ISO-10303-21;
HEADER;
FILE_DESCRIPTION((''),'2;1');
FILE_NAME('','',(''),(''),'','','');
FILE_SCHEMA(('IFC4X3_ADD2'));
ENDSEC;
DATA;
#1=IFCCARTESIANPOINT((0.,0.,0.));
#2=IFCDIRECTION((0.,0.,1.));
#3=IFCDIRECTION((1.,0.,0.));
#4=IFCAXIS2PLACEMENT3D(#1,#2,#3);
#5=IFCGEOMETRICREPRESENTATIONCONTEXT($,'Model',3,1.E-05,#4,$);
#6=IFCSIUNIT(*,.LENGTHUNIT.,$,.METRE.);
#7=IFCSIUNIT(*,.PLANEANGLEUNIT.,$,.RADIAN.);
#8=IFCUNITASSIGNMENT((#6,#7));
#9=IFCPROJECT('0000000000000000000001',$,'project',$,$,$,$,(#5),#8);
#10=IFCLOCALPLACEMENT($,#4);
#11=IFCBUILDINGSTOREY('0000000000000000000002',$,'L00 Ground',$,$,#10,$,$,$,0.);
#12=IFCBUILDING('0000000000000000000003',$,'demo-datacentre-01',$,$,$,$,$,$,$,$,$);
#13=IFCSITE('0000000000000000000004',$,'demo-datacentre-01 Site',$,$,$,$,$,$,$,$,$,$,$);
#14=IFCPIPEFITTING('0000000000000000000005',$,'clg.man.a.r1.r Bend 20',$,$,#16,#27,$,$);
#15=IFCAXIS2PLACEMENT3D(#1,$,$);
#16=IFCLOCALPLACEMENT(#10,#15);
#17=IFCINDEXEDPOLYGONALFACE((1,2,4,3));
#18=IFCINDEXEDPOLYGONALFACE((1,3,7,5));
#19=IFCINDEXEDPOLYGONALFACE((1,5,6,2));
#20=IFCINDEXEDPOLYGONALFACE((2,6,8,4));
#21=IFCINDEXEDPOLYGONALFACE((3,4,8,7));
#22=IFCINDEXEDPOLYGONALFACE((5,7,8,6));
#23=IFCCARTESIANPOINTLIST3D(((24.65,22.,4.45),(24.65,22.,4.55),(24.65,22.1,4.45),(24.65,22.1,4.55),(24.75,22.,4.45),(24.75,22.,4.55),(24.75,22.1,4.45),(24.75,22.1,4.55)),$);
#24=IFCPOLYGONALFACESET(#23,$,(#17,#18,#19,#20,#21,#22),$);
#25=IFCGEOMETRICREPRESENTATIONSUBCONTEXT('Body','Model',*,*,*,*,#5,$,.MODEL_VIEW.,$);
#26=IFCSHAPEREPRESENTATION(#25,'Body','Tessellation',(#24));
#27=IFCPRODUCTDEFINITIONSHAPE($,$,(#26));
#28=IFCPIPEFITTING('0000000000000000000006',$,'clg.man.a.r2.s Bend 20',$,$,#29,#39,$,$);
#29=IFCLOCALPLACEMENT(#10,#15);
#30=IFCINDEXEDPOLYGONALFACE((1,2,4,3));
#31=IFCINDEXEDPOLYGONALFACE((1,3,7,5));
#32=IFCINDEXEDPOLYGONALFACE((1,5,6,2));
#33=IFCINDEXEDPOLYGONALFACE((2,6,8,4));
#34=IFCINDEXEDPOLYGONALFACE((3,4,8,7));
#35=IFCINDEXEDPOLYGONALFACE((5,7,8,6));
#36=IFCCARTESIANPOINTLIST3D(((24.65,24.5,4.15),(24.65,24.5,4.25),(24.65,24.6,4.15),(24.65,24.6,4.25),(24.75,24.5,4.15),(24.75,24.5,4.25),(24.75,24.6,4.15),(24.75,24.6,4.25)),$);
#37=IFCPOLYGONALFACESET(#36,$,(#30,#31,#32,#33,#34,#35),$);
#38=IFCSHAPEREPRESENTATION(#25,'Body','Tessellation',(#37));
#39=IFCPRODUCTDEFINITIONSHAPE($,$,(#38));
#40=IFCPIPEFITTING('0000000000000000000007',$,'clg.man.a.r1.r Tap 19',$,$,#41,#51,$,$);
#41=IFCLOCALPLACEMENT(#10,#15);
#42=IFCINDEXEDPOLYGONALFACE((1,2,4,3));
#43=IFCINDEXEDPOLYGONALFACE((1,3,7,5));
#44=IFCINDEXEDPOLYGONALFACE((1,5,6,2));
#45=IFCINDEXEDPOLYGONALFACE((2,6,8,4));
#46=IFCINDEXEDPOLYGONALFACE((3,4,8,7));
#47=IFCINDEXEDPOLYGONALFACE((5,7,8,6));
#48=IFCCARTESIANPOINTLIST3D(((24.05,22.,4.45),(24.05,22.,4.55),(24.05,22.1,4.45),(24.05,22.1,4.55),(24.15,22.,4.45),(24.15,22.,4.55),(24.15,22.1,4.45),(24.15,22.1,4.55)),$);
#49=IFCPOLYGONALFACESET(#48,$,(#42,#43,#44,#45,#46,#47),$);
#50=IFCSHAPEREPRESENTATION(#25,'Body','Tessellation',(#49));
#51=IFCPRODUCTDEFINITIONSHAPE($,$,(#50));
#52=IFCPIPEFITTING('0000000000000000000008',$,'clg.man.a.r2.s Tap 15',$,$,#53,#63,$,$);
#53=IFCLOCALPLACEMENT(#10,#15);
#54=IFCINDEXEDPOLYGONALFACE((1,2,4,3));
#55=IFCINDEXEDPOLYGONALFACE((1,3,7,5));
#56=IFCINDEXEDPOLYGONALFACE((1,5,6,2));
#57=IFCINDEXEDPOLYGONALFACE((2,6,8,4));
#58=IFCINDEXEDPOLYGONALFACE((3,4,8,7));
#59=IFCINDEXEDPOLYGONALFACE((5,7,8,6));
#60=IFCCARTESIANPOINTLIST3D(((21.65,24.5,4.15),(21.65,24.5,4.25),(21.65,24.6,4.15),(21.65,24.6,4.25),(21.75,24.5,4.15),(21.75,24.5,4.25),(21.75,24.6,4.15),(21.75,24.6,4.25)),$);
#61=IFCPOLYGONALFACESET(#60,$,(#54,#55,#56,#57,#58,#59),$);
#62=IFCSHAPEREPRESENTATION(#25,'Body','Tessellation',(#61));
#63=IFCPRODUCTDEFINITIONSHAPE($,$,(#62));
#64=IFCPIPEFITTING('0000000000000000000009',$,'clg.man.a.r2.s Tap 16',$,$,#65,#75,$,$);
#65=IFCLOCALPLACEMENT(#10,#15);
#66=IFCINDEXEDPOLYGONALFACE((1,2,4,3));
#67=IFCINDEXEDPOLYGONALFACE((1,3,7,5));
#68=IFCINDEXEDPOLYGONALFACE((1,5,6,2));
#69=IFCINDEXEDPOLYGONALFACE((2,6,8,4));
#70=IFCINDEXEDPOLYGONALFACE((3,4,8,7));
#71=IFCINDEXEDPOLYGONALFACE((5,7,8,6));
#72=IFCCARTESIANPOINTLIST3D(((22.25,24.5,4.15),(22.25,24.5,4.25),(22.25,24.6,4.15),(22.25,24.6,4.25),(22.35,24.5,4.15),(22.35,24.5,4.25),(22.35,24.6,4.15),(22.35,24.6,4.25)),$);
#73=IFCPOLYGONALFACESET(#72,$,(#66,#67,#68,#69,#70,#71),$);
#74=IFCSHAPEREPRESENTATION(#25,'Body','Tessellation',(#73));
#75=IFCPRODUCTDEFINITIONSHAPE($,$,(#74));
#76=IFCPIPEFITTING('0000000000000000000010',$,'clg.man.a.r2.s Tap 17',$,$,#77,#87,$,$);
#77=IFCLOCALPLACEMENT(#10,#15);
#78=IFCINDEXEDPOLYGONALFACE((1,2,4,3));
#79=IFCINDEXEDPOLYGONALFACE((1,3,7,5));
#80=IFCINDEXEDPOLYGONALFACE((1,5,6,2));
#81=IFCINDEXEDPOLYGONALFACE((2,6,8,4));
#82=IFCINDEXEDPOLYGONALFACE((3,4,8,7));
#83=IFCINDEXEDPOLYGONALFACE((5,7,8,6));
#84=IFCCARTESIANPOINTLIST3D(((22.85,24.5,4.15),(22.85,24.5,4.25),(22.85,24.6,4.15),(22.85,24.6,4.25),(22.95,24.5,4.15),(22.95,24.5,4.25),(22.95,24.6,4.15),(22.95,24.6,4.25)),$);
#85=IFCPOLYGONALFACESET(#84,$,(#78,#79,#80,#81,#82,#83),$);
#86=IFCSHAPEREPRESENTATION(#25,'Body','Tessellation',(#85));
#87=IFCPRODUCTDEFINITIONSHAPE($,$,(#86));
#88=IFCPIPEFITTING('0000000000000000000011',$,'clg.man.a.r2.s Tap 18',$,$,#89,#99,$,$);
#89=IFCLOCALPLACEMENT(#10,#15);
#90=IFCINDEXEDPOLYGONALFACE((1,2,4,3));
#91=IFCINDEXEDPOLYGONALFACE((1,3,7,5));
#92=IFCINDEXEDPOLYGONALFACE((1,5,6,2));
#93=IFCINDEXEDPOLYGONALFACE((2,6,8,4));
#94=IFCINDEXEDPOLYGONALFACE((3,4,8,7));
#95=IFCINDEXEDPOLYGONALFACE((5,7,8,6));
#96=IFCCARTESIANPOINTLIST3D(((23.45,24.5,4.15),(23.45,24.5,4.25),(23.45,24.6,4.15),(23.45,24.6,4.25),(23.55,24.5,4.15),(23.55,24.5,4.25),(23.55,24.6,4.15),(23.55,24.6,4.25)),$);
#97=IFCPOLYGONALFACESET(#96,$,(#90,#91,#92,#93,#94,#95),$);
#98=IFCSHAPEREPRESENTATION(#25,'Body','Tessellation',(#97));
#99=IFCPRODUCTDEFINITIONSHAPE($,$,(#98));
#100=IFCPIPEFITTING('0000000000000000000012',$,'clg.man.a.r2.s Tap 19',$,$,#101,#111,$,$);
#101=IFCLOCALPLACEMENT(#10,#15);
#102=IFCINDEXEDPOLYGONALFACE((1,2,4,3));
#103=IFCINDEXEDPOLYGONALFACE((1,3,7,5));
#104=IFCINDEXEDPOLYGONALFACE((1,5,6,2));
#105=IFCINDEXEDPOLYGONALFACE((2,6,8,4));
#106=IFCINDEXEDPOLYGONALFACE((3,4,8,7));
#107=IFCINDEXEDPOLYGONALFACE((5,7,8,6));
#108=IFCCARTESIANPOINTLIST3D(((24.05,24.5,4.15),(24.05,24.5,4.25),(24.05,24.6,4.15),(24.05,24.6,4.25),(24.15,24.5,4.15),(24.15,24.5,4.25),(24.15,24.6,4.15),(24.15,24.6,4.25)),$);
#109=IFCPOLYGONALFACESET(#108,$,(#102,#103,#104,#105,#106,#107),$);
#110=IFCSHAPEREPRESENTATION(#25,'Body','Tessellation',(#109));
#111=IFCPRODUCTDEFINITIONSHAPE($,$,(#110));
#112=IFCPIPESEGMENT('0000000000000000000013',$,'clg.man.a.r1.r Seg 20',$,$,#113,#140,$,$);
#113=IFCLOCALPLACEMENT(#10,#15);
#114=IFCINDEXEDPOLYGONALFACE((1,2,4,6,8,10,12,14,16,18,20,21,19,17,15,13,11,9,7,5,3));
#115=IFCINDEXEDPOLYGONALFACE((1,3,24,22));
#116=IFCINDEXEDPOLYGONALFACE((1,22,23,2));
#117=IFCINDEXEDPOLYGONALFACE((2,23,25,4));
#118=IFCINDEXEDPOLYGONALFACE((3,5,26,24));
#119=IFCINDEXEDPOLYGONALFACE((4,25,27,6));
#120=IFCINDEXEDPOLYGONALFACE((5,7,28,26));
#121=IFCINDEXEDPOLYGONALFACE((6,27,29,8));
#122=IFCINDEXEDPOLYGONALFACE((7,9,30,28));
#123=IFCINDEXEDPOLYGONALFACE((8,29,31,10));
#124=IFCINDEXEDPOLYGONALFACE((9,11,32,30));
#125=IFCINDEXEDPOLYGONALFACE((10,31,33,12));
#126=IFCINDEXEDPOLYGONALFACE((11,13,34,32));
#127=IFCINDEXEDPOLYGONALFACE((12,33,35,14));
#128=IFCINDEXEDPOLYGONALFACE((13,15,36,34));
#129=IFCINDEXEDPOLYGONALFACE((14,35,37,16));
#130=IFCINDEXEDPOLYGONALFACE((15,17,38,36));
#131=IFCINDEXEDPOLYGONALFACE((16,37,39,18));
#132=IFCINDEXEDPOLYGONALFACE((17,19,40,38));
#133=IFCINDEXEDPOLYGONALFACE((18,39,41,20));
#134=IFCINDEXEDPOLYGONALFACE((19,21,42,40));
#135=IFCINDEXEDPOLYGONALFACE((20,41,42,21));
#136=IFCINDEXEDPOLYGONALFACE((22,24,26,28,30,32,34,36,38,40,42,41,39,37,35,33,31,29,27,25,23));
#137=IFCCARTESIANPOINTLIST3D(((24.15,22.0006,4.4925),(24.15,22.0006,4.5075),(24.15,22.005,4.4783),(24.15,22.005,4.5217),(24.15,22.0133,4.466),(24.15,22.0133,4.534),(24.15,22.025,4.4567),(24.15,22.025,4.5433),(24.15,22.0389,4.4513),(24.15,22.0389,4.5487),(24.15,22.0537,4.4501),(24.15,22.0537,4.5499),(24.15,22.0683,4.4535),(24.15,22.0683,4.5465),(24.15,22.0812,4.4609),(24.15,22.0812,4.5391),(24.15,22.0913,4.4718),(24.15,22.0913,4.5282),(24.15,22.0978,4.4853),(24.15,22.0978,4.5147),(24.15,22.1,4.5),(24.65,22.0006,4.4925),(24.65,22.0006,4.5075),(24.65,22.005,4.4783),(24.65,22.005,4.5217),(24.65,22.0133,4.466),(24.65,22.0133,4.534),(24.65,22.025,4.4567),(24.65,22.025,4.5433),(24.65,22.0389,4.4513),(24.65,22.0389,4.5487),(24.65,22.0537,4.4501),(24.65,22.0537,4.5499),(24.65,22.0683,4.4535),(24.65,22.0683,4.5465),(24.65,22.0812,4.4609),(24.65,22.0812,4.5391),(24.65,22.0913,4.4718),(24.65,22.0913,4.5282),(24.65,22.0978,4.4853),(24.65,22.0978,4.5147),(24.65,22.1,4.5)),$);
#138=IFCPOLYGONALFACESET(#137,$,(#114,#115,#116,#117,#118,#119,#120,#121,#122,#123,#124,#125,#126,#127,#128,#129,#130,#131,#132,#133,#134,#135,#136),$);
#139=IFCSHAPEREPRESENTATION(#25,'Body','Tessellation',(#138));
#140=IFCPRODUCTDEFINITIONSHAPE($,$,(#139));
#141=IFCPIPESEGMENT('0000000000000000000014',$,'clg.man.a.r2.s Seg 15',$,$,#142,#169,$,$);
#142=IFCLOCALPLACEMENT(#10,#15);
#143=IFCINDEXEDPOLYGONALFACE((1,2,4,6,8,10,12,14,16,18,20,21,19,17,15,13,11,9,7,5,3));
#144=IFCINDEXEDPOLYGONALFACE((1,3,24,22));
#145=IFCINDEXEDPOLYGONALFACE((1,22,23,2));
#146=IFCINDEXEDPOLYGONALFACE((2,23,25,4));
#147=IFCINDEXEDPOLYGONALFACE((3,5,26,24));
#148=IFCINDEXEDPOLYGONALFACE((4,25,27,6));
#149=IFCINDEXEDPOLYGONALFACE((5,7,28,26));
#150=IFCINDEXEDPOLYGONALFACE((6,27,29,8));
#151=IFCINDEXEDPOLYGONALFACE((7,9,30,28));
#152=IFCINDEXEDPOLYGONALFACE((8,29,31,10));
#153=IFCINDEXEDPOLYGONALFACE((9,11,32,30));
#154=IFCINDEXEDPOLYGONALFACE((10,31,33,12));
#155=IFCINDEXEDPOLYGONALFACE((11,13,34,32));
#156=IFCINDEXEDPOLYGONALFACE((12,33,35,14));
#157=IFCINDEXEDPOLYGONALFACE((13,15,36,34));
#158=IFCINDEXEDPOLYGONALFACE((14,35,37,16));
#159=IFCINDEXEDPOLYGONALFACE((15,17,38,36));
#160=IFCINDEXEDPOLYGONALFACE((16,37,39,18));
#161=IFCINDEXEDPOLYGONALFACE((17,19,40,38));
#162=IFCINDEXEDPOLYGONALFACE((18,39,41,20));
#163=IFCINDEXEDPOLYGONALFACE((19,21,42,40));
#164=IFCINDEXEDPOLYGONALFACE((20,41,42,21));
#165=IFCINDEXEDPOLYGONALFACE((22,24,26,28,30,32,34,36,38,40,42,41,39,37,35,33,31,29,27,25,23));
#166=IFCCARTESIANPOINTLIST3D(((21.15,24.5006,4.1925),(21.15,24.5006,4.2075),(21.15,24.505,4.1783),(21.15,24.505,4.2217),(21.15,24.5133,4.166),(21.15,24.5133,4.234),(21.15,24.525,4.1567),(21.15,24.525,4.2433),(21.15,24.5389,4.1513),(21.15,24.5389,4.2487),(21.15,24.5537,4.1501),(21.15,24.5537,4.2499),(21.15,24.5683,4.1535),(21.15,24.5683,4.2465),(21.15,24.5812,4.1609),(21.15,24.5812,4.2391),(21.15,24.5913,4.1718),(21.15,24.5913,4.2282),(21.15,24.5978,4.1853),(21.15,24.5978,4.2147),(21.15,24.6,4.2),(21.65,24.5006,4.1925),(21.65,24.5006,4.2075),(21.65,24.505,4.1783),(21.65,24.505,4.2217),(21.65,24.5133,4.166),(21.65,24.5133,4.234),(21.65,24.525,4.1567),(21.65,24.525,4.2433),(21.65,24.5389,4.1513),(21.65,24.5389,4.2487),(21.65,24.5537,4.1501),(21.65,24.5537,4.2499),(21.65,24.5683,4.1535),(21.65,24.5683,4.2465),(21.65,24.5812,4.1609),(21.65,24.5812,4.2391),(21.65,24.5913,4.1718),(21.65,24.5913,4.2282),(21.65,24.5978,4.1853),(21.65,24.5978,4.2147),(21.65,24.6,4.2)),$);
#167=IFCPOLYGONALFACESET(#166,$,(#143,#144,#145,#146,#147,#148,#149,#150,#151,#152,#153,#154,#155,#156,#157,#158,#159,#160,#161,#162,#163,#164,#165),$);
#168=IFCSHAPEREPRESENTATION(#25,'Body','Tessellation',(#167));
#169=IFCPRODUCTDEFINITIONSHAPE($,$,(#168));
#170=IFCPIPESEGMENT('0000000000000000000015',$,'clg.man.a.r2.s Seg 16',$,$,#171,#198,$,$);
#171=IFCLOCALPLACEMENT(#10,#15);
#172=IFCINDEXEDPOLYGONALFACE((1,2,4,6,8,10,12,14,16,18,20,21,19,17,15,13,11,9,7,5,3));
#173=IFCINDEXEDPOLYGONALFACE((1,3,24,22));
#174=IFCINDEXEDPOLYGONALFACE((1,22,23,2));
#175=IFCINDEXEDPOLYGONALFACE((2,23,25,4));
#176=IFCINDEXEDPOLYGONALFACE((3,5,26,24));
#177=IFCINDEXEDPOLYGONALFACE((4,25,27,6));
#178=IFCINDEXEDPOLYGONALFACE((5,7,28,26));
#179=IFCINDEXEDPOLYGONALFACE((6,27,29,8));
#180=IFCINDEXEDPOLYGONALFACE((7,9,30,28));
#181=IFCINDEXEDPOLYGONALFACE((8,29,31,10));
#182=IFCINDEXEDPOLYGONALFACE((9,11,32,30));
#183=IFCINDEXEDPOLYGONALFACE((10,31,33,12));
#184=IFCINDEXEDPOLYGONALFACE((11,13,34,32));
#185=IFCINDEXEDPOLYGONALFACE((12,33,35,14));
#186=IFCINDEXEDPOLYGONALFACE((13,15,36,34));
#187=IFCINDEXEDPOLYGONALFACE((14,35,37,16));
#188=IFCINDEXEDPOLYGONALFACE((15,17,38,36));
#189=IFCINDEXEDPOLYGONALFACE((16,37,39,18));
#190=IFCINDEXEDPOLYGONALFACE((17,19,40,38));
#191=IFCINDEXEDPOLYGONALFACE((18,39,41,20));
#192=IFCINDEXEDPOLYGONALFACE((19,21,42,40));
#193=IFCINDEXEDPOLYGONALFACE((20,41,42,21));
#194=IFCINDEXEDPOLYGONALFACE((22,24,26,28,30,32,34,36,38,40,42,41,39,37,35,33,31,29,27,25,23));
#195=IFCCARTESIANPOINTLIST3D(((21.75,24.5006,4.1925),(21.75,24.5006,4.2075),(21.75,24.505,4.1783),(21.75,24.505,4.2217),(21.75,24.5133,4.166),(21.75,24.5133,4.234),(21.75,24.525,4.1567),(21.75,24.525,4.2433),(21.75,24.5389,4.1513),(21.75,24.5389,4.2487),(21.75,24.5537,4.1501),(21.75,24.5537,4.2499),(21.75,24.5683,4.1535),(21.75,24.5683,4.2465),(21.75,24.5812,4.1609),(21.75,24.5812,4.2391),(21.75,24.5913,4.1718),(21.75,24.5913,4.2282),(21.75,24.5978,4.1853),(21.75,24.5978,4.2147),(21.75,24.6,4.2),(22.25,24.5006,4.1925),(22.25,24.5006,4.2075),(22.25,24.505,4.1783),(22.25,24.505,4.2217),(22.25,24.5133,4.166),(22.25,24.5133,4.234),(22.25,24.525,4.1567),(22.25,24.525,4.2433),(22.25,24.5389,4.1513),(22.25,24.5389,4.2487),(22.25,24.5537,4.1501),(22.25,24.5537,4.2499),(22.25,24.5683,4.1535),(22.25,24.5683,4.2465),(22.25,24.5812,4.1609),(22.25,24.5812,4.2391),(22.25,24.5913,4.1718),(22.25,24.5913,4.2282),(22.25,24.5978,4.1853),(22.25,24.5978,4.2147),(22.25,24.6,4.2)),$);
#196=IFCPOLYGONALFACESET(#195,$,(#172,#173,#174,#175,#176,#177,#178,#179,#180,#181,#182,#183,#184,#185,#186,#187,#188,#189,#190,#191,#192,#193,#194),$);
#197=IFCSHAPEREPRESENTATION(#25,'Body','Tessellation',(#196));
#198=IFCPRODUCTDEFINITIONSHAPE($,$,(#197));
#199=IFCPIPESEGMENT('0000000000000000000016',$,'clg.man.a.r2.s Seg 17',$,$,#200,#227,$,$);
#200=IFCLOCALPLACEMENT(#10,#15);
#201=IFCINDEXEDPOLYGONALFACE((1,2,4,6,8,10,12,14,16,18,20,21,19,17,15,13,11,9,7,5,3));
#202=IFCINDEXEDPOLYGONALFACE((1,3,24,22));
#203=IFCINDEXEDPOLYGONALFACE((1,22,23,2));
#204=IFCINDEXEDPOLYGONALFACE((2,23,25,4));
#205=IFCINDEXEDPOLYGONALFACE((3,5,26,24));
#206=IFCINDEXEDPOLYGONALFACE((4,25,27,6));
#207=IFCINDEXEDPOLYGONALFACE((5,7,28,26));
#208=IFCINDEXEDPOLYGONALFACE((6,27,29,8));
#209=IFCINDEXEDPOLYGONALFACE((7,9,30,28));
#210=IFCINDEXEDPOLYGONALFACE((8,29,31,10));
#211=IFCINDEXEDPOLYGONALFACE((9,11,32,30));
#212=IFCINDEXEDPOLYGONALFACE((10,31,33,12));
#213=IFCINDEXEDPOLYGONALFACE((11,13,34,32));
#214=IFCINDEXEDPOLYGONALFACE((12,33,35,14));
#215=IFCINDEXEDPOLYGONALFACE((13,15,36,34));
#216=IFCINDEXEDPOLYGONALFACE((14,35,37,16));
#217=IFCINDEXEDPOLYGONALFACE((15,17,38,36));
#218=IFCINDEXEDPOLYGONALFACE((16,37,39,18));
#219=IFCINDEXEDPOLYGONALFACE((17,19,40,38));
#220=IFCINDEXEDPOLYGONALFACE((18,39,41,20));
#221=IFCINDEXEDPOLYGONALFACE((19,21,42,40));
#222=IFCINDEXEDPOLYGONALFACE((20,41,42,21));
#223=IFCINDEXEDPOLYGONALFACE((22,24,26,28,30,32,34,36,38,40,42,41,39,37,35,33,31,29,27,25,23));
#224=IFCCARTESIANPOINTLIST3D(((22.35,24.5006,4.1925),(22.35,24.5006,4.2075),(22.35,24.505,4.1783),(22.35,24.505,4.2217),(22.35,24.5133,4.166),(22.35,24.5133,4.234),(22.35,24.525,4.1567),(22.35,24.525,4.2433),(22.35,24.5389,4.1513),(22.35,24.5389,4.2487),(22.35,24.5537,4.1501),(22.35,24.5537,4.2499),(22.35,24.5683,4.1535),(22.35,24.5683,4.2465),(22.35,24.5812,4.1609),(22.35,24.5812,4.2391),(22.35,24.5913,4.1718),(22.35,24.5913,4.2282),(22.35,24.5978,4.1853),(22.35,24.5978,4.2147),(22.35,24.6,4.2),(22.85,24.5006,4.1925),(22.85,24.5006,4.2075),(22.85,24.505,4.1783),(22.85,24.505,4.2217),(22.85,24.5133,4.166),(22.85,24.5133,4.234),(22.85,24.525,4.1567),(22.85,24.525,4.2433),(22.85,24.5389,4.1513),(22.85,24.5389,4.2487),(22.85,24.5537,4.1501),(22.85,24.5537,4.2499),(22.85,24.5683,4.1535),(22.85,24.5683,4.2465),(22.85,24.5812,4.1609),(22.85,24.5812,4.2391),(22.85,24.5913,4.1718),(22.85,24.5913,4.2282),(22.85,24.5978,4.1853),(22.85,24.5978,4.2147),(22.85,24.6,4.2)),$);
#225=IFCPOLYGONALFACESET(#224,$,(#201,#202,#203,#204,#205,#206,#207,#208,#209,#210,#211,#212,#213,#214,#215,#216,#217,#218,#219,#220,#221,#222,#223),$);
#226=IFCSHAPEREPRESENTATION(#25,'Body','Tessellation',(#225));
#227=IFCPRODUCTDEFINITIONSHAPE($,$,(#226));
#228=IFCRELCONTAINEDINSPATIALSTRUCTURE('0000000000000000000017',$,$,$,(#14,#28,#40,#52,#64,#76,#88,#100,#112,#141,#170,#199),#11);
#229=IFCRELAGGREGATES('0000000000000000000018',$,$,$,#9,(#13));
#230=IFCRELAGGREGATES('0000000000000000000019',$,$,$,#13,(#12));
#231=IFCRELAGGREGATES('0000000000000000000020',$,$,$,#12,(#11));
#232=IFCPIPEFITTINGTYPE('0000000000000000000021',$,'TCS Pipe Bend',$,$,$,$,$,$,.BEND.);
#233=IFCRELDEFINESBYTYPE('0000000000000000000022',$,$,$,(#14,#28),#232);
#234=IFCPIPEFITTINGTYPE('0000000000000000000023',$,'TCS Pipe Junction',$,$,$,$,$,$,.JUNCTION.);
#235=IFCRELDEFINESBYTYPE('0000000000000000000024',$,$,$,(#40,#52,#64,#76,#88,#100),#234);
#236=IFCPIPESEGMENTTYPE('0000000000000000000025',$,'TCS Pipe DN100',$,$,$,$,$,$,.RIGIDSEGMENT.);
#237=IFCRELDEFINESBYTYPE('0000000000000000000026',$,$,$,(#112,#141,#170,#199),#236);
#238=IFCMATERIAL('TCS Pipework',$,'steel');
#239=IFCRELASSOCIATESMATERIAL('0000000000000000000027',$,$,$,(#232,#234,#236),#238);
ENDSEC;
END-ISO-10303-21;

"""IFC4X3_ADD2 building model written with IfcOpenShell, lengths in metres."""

from ifc_helpers import new_model, si_unit, frame, origin_with_axes, place, context, subcontext, project, spatial, rectangle, circle, extrude, material, type_object, element, save


model = new_model("IFC4X3_ADD2")

# Units and contexts
model_context = context("Model", 3, precision=1e-05, world=origin_with_axes())
body_context = subcontext(model_context, "Body", "Model", "MODEL_VIEW")
ifc_project = project(units=[si_unit("LENGTHUNIT", "METRE"), si_unit("PLANEANGLEUNIT", "RADIAN")], contexts=[model_context])

# Site, building, storey
site = spatial("IfcSite", under=ifc_project, Name="demo-datacentre-01 Site")
building = spatial("IfcBuilding", under=site, Name="demo-datacentre-01")
storey_placement = place(None, origin_with_axes())
storey = spatial("IfcBuildingStorey", under=building, at=storey_placement, Name="L00 Ground", Elevation=0.0)

# Pipe fittings
ifc_material = material(Name="TCS Pipework", Category="steel")
pipe_fitting_type_1 = type_object("IfcPipeFittingType", Name="TCS Pipe Bend", PredefinedType="BEND", material=ifc_material)
for number, where, z_axis, x_axis, name in (
    (1, (24.7, 22.05, 4.45), (0.0, 0.0, 1.0), (1.0, 0.0, 0.0), "clg.man.a.r1.r Bend 20"),
    (2, (24.7, 24.55, 4.15), (0.0, 0.0, 1.0), (1.0, 0.0, 0.0), "clg.man.a.r2.s Bend 20"),
):
    element("IfcPipeFitting", number, at=place(storey_placement, frame(where, z_axis=z_axis, x_axis=x_axis)), inside=storey, type_object=pipe_fitting_type_1, Name=name, context=body_context, shape_type="SweptSolid", body=[
        extrude(rectangle(XDim=0.1, YDim=0.1), origin_with_axes(), (0.0, 0.0, 1.0), 0.1),
    ])
pipe_fitting_type_2 = type_object("IfcPipeFittingType", Name="TCS Pipe Junction", PredefinedType="JUNCTION", material=ifc_material)
for number, where, z_axis, x_axis, name in (
    (3, (24.1, 22.05, 4.45), (0.0, 0.0, 1.0), (1.0, 0.0, 0.0), "clg.man.a.r1.r Tap 19"),
    (4, (21.7, 24.55, 4.15), (0.0, 0.0, 1.0), (1.0, 0.0, 0.0), "clg.man.a.r2.s Tap 15"),
    (5, (22.3, 24.55, 4.15), (0.0, 0.0, 1.0), (1.0, 0.0, 0.0), "clg.man.a.r2.s Tap 16"),
    (6, (22.9, 24.55, 4.15), (0.0, 0.0, 1.0), (1.0, 0.0, 0.0), "clg.man.a.r2.s Tap 17"),
    (7, (23.5, 24.55, 4.15), (0.0, 0.0, 1.0), (1.0, 0.0, 0.0), "clg.man.a.r2.s Tap 18"),
    (8, (24.1, 24.55, 4.15), (0.0, 0.0, 1.0), (1.0, 0.0, 0.0), "clg.man.a.r2.s Tap 19"),
):
    element("IfcPipeFitting", number, at=place(storey_placement, frame(where, z_axis=z_axis, x_axis=x_axis)), inside=storey, type_object=pipe_fitting_type_2, Name=name, context=body_context, shape_type="SweptSolid", body=[
        extrude(rectangle(XDim=0.1, YDim=0.1), origin_with_axes(), (0.0, 0.0, 1.0), 0.1),
    ])

# Pipe segments
pipe_segment_type_1 = type_object("IfcPipeSegmentType", Name="TCS Pipe DN100", PredefinedType="RIGIDSEGMENT", material=ifc_material)
for number, where, z_axis, x_axis, name in (
    (9, (24.15, 22.05, 4.5), (1.0, 0.0, 0.0), (0.0, 1.0, 0.0), "clg.man.a.r1.r Seg 20"),
    (10, (21.15, 24.55, 4.2), (1.0, 0.0, 0.0), (0.0, 1.0, 0.0), "clg.man.a.r2.s Seg 15"),
):
    element("IfcPipeSegment", number, at=place(storey_placement, frame(where, z_axis=z_axis, x_axis=x_axis)), inside=storey, type_object=pipe_segment_type_1, Name=name, context=body_context, shape_type="SweptSolid", body=[
        extrude(circle(Radius=0.05), origin_with_axes(), (0.0, 0.0, 1.0), 0.5),
    ])
for number, where, z_axis, x_axis, name in (
    (11, (21.75, 24.55, 4.2), (1.0, 0.0, 0.0), (0.0, 1.0, 0.0), "clg.man.a.r2.s Seg 16"),
    (12, (22.35, 24.55, 4.2), (1.0, 0.0, 0.0), (0.0, 1.0, 0.0), "clg.man.a.r2.s Seg 17"),
):
    element("IfcPipeSegment", number, at=place(storey_placement, frame(where, z_axis=z_axis, x_axis=x_axis)), inside=storey, type_object=pipe_segment_type_1, Name=name, context=body_context, shape_type="SweptSolid", body=[
        extrude(circle(Radius=0.05), origin_with_axes(), (0.0, 0.0, 1.0), 0.5),
    ])

save(model, "model.ifc")
